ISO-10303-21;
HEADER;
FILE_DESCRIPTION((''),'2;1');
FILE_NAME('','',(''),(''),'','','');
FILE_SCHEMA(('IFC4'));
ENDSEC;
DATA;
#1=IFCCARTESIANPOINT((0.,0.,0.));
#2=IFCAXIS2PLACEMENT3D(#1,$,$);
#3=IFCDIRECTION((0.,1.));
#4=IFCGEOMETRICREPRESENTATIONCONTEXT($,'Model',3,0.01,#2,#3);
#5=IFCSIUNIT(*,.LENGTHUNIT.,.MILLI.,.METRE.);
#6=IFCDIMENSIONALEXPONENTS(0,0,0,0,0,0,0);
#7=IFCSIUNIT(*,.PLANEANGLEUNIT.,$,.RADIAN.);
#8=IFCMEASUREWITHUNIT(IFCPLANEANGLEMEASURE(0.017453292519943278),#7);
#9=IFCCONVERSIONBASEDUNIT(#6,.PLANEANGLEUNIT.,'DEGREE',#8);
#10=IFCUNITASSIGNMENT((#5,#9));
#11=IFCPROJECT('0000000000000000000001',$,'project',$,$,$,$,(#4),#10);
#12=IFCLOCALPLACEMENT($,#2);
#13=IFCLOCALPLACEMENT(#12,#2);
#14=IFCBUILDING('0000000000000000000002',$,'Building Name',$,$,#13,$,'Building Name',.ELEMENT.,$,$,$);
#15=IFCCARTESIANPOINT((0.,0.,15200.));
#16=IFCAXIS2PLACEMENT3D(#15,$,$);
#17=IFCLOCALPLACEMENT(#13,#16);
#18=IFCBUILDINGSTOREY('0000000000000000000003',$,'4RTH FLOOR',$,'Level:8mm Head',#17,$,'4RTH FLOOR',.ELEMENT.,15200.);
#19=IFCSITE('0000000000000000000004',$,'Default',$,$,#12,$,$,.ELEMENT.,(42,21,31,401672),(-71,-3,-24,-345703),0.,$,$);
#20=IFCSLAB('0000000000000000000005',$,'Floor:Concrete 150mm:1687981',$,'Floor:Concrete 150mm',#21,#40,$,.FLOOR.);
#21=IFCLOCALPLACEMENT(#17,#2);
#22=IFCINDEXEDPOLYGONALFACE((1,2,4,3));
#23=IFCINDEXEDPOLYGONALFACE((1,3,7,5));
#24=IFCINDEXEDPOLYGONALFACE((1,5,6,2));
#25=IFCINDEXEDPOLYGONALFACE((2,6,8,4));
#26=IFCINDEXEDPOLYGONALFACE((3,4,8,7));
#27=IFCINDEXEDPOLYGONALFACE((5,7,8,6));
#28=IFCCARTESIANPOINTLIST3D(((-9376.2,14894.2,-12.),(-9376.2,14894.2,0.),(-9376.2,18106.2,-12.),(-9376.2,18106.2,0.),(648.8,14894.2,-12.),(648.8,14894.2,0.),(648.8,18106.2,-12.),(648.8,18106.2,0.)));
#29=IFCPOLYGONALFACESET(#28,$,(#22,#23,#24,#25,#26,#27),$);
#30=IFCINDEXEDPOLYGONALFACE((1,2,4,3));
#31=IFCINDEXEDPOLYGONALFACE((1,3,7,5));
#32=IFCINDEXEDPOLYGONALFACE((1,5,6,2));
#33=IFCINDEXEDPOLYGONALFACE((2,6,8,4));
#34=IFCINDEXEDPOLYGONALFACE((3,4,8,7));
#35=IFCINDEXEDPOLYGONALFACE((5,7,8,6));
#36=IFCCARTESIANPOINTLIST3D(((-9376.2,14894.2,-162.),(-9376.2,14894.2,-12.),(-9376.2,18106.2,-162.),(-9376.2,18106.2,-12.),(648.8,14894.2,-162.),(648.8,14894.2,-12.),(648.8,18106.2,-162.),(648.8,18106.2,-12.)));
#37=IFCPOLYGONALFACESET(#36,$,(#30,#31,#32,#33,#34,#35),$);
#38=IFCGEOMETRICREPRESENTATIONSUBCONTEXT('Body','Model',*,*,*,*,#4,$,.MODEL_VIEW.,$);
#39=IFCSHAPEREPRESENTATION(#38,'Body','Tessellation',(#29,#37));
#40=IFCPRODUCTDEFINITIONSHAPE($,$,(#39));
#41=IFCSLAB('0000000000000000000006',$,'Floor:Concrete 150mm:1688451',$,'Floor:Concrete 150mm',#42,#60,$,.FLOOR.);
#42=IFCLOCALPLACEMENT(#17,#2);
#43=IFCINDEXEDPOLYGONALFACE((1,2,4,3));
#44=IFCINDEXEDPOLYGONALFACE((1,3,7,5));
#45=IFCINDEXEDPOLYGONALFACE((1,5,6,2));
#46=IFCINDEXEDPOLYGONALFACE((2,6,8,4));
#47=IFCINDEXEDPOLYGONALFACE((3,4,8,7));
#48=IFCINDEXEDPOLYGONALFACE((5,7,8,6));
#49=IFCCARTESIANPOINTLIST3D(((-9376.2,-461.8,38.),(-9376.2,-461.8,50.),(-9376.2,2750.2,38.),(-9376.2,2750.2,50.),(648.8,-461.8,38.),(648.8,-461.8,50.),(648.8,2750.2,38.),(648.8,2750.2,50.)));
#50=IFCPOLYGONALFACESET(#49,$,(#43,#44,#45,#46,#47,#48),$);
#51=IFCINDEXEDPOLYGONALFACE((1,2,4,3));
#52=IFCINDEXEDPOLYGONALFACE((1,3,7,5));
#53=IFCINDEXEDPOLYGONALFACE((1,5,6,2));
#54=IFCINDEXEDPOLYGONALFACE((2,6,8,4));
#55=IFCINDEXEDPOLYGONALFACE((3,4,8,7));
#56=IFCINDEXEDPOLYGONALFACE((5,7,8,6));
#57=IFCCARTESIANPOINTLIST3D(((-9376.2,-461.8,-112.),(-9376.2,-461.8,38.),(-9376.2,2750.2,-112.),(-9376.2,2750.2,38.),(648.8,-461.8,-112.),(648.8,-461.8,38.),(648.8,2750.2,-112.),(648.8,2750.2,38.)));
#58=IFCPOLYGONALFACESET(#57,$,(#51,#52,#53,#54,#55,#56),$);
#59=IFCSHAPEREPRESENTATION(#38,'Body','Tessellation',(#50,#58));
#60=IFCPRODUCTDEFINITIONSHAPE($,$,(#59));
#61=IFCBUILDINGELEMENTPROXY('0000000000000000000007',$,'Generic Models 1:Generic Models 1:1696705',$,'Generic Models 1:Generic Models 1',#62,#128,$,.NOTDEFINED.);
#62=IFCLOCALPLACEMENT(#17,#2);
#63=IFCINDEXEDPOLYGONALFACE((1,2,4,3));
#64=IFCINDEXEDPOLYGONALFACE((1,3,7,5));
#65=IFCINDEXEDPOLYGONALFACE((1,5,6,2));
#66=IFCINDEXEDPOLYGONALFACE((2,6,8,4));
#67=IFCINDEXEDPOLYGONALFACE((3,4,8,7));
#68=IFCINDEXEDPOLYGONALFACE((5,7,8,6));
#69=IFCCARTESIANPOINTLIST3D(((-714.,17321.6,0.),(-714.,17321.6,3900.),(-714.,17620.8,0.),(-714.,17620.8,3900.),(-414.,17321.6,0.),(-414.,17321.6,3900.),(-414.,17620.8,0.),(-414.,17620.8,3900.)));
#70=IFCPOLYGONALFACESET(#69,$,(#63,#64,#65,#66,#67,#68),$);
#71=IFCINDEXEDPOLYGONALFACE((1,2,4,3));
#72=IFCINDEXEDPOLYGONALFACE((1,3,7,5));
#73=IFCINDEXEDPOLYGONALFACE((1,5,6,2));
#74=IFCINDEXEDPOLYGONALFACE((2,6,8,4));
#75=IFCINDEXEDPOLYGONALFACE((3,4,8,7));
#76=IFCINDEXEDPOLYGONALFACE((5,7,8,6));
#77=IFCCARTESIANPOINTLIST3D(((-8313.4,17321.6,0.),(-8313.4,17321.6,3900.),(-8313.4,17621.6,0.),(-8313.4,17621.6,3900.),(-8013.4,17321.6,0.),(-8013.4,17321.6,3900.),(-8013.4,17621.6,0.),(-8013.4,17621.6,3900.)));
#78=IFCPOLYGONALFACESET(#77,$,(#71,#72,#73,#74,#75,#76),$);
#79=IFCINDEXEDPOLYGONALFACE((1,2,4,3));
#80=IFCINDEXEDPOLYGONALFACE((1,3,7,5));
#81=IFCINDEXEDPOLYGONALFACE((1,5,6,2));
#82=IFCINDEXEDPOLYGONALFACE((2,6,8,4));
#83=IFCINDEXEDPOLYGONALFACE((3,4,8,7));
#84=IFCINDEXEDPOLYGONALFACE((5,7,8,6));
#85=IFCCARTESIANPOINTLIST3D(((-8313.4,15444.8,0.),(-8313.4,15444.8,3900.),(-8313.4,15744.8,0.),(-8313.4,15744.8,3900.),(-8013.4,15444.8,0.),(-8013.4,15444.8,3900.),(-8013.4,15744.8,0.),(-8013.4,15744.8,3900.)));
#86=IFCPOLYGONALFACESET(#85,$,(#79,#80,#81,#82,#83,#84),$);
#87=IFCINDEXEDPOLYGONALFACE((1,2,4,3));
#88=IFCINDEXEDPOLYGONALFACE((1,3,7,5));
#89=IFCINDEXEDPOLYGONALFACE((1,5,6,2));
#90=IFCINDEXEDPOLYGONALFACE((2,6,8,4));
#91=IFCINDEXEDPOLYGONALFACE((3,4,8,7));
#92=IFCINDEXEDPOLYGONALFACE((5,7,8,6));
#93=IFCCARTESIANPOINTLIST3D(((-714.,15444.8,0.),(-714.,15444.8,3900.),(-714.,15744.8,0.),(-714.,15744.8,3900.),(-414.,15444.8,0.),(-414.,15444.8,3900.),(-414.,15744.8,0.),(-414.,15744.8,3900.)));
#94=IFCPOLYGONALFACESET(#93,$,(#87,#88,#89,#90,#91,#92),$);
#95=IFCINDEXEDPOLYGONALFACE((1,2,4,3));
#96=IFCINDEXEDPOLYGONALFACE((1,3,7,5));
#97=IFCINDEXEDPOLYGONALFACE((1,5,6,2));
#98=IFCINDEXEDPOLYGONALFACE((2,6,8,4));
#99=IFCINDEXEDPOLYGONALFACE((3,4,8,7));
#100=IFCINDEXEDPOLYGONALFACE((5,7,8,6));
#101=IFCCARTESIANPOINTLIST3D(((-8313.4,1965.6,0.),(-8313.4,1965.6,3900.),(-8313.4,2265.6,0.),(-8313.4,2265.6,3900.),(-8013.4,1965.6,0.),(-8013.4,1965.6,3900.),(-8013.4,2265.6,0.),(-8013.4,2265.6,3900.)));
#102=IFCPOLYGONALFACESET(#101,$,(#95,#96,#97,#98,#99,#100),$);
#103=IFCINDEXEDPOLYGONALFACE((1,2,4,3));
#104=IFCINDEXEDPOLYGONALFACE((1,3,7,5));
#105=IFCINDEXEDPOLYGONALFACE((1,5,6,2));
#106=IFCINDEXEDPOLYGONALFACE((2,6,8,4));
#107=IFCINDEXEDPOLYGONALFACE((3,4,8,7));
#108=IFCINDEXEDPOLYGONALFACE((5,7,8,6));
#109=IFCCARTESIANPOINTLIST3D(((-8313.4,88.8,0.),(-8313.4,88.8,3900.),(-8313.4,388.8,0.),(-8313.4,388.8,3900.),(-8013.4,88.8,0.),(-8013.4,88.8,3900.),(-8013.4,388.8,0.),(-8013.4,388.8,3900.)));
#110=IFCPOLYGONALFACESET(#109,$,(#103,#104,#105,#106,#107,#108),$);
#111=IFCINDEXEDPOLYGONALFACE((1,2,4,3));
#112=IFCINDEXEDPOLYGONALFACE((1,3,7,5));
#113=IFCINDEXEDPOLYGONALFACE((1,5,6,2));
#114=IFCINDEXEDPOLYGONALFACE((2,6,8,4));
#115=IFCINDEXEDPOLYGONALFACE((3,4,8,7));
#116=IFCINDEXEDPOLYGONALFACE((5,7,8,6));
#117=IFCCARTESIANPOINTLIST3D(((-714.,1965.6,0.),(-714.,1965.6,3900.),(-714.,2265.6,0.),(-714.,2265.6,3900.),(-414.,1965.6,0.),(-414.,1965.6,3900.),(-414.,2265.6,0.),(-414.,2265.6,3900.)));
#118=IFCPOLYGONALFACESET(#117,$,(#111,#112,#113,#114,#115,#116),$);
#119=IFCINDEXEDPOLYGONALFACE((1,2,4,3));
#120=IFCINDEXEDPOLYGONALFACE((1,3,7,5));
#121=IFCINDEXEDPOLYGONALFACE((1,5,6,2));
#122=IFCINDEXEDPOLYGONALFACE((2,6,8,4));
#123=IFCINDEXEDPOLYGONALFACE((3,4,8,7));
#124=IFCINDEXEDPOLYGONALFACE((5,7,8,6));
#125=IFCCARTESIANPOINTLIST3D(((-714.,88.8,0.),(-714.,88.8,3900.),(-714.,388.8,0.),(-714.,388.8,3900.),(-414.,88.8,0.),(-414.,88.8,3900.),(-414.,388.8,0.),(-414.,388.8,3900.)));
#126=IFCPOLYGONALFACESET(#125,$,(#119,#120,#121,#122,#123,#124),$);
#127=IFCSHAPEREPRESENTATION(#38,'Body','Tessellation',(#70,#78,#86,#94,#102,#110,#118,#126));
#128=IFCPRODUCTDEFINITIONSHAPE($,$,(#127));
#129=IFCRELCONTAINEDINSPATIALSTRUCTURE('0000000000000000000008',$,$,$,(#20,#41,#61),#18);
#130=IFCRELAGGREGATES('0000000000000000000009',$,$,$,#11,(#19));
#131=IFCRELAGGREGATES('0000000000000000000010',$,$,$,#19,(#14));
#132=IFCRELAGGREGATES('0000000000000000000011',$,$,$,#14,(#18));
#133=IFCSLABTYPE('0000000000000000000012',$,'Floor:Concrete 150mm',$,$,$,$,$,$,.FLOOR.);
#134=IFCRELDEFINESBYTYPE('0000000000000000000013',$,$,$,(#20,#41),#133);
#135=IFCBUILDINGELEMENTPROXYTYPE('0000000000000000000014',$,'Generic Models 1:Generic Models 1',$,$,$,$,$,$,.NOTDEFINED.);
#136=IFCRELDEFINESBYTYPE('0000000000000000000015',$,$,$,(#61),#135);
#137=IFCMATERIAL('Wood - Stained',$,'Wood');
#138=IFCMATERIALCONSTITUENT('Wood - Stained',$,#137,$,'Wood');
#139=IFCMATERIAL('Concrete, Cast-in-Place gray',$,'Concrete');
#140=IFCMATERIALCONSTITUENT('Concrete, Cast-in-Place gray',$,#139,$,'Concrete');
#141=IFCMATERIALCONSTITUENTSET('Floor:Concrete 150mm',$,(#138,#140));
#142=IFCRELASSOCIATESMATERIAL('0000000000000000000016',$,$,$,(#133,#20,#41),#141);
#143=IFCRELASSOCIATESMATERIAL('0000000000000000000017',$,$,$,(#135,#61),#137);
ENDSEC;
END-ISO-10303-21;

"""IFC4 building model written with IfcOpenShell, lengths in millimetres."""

from ifc_helpers import new_model, entity, si_unit, converted_unit, direction, frame, origin, place, context, subcontext, project, spatial, indexed_curve, outline, extrude, source, transform, mapped, material, constituent, constituent_set, type_object, type_shapes, element, save


model = new_model("IFC4")

# Units and contexts
model_context = context("Model", 3, precision=0.01, world=origin(), true_north=direction((0.0, 1.0)))
body_context = subcontext(model_context, "Body", "Model", "MODEL_VIEW")
ifc_project = project(units=[si_unit("LENGTHUNIT", "METRE", prefix="MILLI"), converted_unit("PLANEANGLEUNIT", "DEGREE", entity("IfcPlaneAngleMeasure", 0.017453292519943278), si_unit("PLANEANGLEUNIT", "RADIAN"), dimensions=[0, 0, 0, 0, 0, 0, 0])], contexts=[model_context])

# Site, building, storey
site_placement = place(None, origin())
site = spatial("IfcSite", under=ifc_project, at=site_placement, Name="Default", CompositionType="ELEMENT", RefLatitude=(42, 21, 31, 401672), RefLongitude=(-71, -3, -24, -345703), RefElevation=0.0)
building_placement = place(site_placement, origin())
building = spatial("IfcBuilding", under=site, at=building_placement, Name="Building Name", LongName="Building Name", CompositionType="ELEMENT")
storey_placement = place(building_placement, frame((0.0, 0.0, 15200.0)))
storey = spatial("IfcBuildingStorey", under=building, at=storey_placement, Name="4RTH FLOOR", ObjectType="Level:8mm Head", LongName="4RTH FLOOR", CompositionType="ELEMENT", Elevation=15200.0)

# Slabs
ifc_material_1 = material(Name="Wood - Stained", Category="Wood")
ifc_constituent_1 = constituent(ifc_material_1, Name="Wood - Stained", Category="Wood")
ifc_material_2 = material(Name="Concrete, Cast-in-Place gray", Category="Concrete")
ifc_constituent_2 = constituent(ifc_material_2, Name="Concrete, Cast-in-Place gray", Category="Concrete")
ifc_constituent_set = constituent_set(constituents=[ifc_constituent_1, ifc_constituent_2], Name="Floor:Concrete 150mm")
slab_type = type_object("IfcSlabType", Name="Floor:Concrete 150mm", PredefinedType="FLOOR", material=ifc_constituent_set)
slab_1_placement = place(storey_placement, origin())
element("IfcSlab", 1, at=slab_1_placement, inside=storey, type_object=slab_type, material=ifc_constituent_set, Name="Floor:Concrete 150mm:1687981", ObjectType="Floor:Concrete 150mm", PredefinedType="FLOOR", context=body_context, shape_type="SweptSolid", body=[
    extrude(outline(indexed_curve([(-5012.5, -1606.0), (5012.5, -1606.0), (5012.5, 1606.0), (-5012.5, 1606.0), (-5012.5, -1606.0)], self_intersect=False)), frame((-4363.7, 16500.2, -12.0), z_axis=(0.0, 0.0, 1.0), x_axis=(-1.0, 0.0, 0.0)), (0.0, 0.0, 1.0), 12.0),
    extrude(outline(indexed_curve([(-5012.5, -1606.0), (5012.5, -1606.0), (5012.5, 1606.0), (-5012.5, 1606.0), (-5012.5, -1606.0)], self_intersect=False)), frame((-4363.7, 16500.2, -162.0), z_axis=(0.0, 0.0, 1.0), x_axis=(-1.0, 0.0, 0.0)), (0.0, 0.0, 1.0), 150.0),
])
slab_2_placement = place(storey_placement, origin())
element("IfcSlab", 2, at=slab_2_placement, inside=storey, type_object=slab_type, material=ifc_constituent_set, Name="Floor:Concrete 150mm:1688451", ObjectType="Floor:Concrete 150mm", PredefinedType="FLOOR", context=body_context, shape_type="SweptSolid", body=[
    extrude(outline(indexed_curve([(-5012.5, -1606.0), (5012.5, -1606.0), (5012.5, 1606.0), (-5012.5, 1606.0), (-5012.5, -1606.0)], self_intersect=False)), frame((-4363.7, 1144.2, 38.0), z_axis=(0.0, 0.0, 1.0), x_axis=(-1.0, 0.0, 0.0)), (0.0, 0.0, 1.0), 12.0),
    extrude(outline(indexed_curve([(-5012.5, -1606.0), (5012.5, -1606.0), (5012.5, 1606.0), (-5012.5, 1606.0), (-5012.5, -1606.0)], self_intersect=False)), frame((-4363.7, 1144.2, -112.0), z_axis=(0.0, 0.0, 1.0), x_axis=(-1.0, 0.0, 0.0)), (0.0, 0.0, 1.0), 150.0),
])

# Building element proxy
building_element_proxy_type_1 = type_object("IfcBuildingElementProxyType", Name="Generic Models 1:Generic Models 1", PredefinedType="NOTDEFINED", material=ifc_material_1)
shared_shape_1 = source(origin(), body_context, "Body", "SweptSolid", [
    extrude(outline(indexed_curve([(-149.6, -150.0), (149.6, -150.0), (149.6, 150.0), (-149.6, 150.0), (-149.6, -150.0)], self_intersect=False)), frame((-564.0, 17471.2, 15200.0), z_axis=(0.0, 0.0, 1.0), x_axis=(0.0, -1.0, 0.0)), (0.0, 0.0, 1.0), 3900.0),
    extrude(outline(indexed_curve([(-150.0, -150.0), (150.0, -150.0), (150.0, 150.0), (-150.0, 150.0), (-150.0, -150.0)], self_intersect=False)), frame((-8163.4, 17471.6, 15200.0), z_axis=(0.0, 0.0, 1.0), x_axis=(-1.0, 0.0, 0.0)), (0.0, 0.0, 1.0), 3900.0),
    extrude(outline(indexed_curve([(-150.0, -150.0), (150.0, -150.0), (150.0, 150.0), (-150.0, 150.0), (-150.0, -150.0)], self_intersect=False)), frame((-8163.4, 15594.8, 15200.0), z_axis=(0.0, 0.0, 1.0), x_axis=(-1.0, 0.0, 0.0)), (0.0, 0.0, 1.0), 3900.0),
    extrude(outline(indexed_curve([(-150.0, -150.0), (150.0, -150.0), (150.0, 150.0), (-150.0, 150.0), (-150.0, -150.0)], self_intersect=False)), frame((-564.0, 15594.8, 15200.0), z_axis=(0.0, 0.0, 1.0), x_axis=(0.0, -1.0, 0.0)), (0.0, 0.0, 1.0), 3900.0),
    extrude(outline(indexed_curve([(-150.0, -150.0), (150.0, -150.0), (150.0, 150.0), (-150.0, 150.0), (-150.0, -150.0)], self_intersect=False)), frame((-8163.4, 2115.6, 15200.0), z_axis=(0.0, 0.0, 1.0), x_axis=(-1.0, 0.0, 0.0)), (0.0, 0.0, 1.0), 3900.0),
    extrude(outline(indexed_curve([(-150.0, -150.0), (150.0, -150.0), (150.0, 150.0), (-150.0, 150.0), (-150.0, -150.0)], self_intersect=False)), frame((-8163.4, 238.8, 15200.0), z_axis=(0.0, 0.0, 1.0), x_axis=(-1.0, 0.0, 0.0)), (0.0, 0.0, 1.0), 3900.0),
    extrude(outline(indexed_curve([(-150.0, -150.0), (150.0, -150.0), (150.0, 150.0), (-150.0, 150.0), (-150.0, -150.0)], self_intersect=False)), frame((-564.0, 2115.6, 15200.0), z_axis=(0.0, 0.0, 1.0), x_axis=(0.0, -1.0, 0.0)), (0.0, 0.0, 1.0), 3900.0),
    extrude(outline(indexed_curve([(-150.0, -150.0), (150.0, -150.0), (150.0, 150.0), (-150.0, 150.0), (-150.0, -150.0)], self_intersect=False)), frame((-564.0, 238.8, 15200.0), z_axis=(0.0, 0.0, 1.0), x_axis=(0.0, -1.0, 0.0)), (0.0, 0.0, 1.0), 3900.0),
])
type_shapes(building_element_proxy_type_1, [shared_shape_1])
proxy_1_placement = place(storey_placement, frame((0.0, 0.0, -15200.0)))
element("IfcBuildingElementProxy", 3, at=proxy_1_placement, inside=storey, type_object=building_element_proxy_type_1, material=ifc_material_1, Name="Generic Models 1:Generic Models 1:1696705", ObjectType="Generic Models 1:Generic Models 1", PredefinedType="NOTDEFINED", context=body_context, shape_type="MappedRepresentation", body=[
    mapped(shared_shape_1, transform((0.0, 0.0, 0.0), scale=1.0)),
])

save(model, "model.ifc")
